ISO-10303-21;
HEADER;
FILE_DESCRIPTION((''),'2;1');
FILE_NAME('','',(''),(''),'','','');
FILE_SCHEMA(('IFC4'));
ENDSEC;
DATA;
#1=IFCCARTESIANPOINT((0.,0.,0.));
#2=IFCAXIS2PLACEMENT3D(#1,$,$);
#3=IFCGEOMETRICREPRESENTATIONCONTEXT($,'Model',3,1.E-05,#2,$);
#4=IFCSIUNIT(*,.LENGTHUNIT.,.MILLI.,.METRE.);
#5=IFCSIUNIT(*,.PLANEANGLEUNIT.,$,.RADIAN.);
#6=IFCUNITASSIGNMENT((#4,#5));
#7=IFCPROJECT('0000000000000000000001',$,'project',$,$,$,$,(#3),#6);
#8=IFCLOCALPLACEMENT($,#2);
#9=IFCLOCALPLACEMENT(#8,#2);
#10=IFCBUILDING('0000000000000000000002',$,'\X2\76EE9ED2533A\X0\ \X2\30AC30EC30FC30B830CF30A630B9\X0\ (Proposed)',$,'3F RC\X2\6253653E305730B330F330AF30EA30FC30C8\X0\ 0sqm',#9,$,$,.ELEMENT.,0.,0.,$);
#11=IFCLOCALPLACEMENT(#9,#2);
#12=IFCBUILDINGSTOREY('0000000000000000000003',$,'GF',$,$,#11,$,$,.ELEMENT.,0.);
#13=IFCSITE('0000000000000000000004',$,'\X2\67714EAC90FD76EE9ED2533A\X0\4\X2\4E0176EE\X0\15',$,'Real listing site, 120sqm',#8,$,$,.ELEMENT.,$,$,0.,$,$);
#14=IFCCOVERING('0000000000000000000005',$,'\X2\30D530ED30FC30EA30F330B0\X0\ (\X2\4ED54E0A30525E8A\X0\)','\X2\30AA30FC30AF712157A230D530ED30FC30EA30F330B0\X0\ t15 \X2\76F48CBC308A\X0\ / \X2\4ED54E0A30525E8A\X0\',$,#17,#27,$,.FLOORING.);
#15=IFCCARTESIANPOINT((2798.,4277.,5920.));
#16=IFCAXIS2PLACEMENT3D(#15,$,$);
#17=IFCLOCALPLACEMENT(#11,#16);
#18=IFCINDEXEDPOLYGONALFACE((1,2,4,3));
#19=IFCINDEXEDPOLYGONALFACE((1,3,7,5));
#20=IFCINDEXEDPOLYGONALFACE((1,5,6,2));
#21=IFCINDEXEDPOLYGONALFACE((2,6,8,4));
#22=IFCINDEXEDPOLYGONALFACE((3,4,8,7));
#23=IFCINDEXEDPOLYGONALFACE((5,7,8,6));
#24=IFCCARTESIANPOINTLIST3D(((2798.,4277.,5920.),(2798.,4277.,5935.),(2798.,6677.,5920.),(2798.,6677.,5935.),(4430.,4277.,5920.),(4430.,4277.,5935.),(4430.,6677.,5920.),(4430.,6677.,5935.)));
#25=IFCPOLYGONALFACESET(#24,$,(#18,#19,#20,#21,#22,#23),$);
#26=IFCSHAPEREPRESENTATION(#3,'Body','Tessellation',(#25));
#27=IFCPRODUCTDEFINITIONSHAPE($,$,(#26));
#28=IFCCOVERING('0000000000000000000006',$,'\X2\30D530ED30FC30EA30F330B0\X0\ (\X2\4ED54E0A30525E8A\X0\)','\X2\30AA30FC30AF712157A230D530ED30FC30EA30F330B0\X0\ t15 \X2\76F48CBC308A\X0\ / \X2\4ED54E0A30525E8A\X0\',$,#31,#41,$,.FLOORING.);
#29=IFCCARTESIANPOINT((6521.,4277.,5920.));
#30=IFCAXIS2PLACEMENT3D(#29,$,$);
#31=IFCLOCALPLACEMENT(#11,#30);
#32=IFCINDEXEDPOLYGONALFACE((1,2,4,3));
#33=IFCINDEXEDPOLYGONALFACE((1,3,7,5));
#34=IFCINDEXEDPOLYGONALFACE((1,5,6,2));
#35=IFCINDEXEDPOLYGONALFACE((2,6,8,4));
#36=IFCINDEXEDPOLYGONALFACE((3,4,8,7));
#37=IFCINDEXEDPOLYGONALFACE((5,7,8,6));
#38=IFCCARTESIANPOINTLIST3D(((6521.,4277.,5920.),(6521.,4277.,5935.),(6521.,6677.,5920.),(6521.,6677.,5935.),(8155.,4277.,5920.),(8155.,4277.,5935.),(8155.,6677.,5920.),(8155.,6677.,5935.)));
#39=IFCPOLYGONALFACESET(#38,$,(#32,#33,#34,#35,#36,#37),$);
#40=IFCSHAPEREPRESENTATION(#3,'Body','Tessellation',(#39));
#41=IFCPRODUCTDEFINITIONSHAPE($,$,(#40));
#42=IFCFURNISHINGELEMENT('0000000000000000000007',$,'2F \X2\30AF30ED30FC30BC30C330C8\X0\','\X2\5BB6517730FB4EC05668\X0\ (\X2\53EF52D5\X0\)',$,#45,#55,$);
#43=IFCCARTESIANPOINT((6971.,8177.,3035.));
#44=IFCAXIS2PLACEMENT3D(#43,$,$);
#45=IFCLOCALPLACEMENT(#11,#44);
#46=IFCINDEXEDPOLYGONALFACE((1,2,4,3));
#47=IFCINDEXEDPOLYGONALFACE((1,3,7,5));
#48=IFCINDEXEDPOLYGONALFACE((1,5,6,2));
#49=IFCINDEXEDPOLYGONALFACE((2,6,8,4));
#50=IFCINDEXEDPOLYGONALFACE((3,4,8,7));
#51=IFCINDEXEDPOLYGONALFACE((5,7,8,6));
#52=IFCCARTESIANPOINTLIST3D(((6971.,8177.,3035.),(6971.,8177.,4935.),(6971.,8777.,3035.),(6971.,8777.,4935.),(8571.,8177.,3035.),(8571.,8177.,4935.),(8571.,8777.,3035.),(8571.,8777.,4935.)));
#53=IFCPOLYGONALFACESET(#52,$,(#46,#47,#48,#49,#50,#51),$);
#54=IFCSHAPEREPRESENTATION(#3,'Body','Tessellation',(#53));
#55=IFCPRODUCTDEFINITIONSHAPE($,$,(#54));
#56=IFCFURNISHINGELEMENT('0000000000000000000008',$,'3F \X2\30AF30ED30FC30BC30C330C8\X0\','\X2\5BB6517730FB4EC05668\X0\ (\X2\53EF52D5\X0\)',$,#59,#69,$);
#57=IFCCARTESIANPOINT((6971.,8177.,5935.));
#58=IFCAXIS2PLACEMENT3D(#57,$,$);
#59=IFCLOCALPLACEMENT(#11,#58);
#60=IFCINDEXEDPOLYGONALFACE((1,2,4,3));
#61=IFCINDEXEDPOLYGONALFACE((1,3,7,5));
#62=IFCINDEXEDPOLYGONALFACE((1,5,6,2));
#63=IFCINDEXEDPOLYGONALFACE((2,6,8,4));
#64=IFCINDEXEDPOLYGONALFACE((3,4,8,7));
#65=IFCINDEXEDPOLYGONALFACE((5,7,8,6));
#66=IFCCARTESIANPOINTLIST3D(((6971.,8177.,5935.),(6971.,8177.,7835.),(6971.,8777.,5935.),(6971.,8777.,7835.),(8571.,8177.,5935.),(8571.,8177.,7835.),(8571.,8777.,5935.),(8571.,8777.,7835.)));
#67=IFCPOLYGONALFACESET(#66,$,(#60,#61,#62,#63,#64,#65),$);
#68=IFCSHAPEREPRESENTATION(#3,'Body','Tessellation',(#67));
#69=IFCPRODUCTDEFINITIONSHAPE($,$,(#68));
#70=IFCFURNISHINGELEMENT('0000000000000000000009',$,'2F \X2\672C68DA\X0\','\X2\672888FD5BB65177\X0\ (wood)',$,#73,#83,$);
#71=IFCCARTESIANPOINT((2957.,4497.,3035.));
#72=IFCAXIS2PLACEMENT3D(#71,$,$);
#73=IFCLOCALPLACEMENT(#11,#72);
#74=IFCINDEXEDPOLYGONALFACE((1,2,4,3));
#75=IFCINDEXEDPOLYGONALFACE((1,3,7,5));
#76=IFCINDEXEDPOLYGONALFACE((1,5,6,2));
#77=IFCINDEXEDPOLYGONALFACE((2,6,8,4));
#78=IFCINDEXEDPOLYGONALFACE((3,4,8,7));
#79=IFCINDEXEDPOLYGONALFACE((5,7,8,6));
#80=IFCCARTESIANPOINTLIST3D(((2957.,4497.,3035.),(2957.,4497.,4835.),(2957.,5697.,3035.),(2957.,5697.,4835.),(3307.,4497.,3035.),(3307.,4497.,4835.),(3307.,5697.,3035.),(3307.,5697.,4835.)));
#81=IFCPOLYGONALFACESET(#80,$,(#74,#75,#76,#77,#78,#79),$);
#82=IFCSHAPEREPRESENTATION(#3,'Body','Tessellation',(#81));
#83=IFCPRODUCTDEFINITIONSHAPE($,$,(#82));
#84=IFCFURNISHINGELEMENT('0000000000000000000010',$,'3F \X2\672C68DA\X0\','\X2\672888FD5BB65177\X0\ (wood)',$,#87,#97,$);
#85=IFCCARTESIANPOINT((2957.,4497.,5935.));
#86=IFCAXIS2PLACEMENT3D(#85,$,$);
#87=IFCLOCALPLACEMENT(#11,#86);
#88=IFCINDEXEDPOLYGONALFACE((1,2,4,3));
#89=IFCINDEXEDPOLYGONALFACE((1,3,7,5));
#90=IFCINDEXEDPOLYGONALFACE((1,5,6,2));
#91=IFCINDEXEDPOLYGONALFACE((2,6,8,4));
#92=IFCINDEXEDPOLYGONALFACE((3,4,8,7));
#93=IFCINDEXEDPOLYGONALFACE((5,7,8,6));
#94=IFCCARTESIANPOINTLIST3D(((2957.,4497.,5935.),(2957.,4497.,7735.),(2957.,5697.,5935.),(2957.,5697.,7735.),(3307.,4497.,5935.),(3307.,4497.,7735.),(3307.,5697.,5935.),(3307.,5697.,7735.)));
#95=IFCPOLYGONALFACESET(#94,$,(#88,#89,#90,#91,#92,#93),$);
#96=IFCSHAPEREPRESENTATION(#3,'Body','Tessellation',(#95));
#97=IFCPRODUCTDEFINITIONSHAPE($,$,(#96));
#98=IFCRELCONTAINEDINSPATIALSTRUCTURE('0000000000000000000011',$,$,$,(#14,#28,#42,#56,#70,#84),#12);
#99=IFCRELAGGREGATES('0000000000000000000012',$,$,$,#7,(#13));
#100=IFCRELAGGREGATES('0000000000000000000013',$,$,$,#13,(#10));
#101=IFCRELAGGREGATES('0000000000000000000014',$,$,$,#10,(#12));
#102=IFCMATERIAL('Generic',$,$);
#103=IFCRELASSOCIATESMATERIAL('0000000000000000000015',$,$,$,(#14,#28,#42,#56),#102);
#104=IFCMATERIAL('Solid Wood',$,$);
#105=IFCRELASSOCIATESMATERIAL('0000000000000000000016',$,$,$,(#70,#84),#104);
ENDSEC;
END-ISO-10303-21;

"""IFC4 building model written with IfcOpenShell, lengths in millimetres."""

from ifc_helpers import new_model, si_unit, frame, frame_2d, origin, place, context, project, spatial, rectangle, extrude, material, element, save


model = new_model("IFC4")

# Units and contexts
model_context = context("Model", 3, precision=1e-05, world=origin())
ifc_project = project(units=[si_unit("LENGTHUNIT", "METRE", prefix="MILLI"), si_unit("PLANEANGLEUNIT", "RADIAN")], contexts=[model_context])

# Site, building, storey
site_placement = place(None, origin())
site = spatial("IfcSite", under=ifc_project, at=site_placement, Name="東京都目黒区4丁目15", ObjectType="Real listing site, 120sqm", CompositionType="ELEMENT", RefElevation=0.0)
building_placement = place(site_placement, origin())
building = spatial("IfcBuilding", under=site, at=building_placement, Name="目黒区 ガレージハウス (Proposed)", ObjectType="3F RC打放しコンクリート 0sqm", CompositionType="ELEMENT", ElevationOfRefHeight=0.0, ElevationOfTerrain=0.0)
storey_placement = place(building_placement, origin())
storey = spatial("IfcBuildingStorey", under=building, at=storey_placement, Name="GF", CompositionType="ELEMENT", Elevation=0.0)

# Shared definitions
ifc_material_1 = material(Name="Solid Wood")

# Coverings
ifc_material_2 = material(Name="Generic")
covering_1_placement = place(storey_placement, frame((2798.0, 4277.0, 5920.0)))
element("IfcCovering", 1, at=covering_1_placement, inside=storey, material=ifc_material_2, Name="フローリング (仕上げ床)", Description="オーク無垢フローリング t15 直貼り / 仕上げ床", PredefinedType="FLOORING", context=model_context, shape_type="SweptSolid", body=[
    extrude(rectangle(XDim=1632.0, YDim=2400.0, at=frame_2d((816.0, 1200.0))), frame((2798.0, 4277.0, 5920.0)), (0.0, 0.0, 1.0), 15.0),
])
covering_2_placement = place(storey_placement, frame((6521.0, 4277.0, 5920.0)))
element("IfcCovering", 2, at=covering_2_placement, inside=storey, material=ifc_material_2, Name="フローリング (仕上げ床)", Description="オーク無垢フローリング t15 直貼り / 仕上げ床", PredefinedType="FLOORING", context=model_context, shape_type="SweptSolid", body=[
    extrude(rectangle(XDim=1634.0, YDim=2400.0, at=frame_2d((817.0, 1200.0))), frame((6521.0, 4277.0, 5920.0)), (0.0, 0.0, 1.0), 15.0),
])

# Furnishing elements
furnishing_1_placement = place(storey_placement, frame((6971.0, 8177.0, 3035.0)))
element("IfcFurnishingElement", 3, at=furnishing_1_placement, inside=storey, material=ifc_material_2, Name="2F クローゼット", Description="家具・什器 (可動)", context=model_context, shape_type="SweptSolid", body=[
    extrude(rectangle(XDim=1600.0, YDim=600.0, at=frame_2d((800.0, 300.0))), frame((6971.0, 8177.0, 3035.0)), (0.0, 0.0, 1.0), 1900.0),
])
furnishing_2_placement = place(storey_placement, frame((6971.0, 8177.0, 5935.0)))
element("IfcFurnishingElement", 4, at=furnishing_2_placement, inside=storey, material=ifc_material_2, Name="3F クローゼット", Description="家具・什器 (可動)", context=model_context, shape_type="SweptSolid", body=[
    extrude(rectangle(XDim=1600.0, YDim=600.0, at=frame_2d((800.0, 300.0))), frame((6971.0, 8177.0, 5935.0)), (0.0, 0.0, 1.0), 1900.0),
])
furnishing_3_placement = place(storey_placement, frame((2957.0, 4497.0, 3035.0)))
element("IfcFurnishingElement", 5, at=furnishing_3_placement, inside=storey, material=ifc_material_1, Name="2F 本棚", Description="木製家具 (wood)", context=model_context, shape_type="SweptSolid", body=[
    extrude(rectangle(XDim=350.0, YDim=1200.0, at=frame_2d((175.0, 600.0))), frame((2957.0, 4497.0, 3035.0)), (0.0, 0.0, 1.0), 1800.0),
])
furnishing_4_placement = place(storey_placement, frame((2957.0, 4497.0, 5935.0)))
element("IfcFurnishingElement", 6, at=furnishing_4_placement, inside=storey, material=ifc_material_1, Name="3F 本棚", Description="木製家具 (wood)", context=model_context, shape_type="SweptSolid", body=[
    extrude(rectangle(XDim=350.0, YDim=1200.0, at=frame_2d((175.0, 600.0))), frame((2957.0, 4497.0, 5935.0)), (0.0, 0.0, 1.0), 1800.0),
])

save(model, "model.ifc")
